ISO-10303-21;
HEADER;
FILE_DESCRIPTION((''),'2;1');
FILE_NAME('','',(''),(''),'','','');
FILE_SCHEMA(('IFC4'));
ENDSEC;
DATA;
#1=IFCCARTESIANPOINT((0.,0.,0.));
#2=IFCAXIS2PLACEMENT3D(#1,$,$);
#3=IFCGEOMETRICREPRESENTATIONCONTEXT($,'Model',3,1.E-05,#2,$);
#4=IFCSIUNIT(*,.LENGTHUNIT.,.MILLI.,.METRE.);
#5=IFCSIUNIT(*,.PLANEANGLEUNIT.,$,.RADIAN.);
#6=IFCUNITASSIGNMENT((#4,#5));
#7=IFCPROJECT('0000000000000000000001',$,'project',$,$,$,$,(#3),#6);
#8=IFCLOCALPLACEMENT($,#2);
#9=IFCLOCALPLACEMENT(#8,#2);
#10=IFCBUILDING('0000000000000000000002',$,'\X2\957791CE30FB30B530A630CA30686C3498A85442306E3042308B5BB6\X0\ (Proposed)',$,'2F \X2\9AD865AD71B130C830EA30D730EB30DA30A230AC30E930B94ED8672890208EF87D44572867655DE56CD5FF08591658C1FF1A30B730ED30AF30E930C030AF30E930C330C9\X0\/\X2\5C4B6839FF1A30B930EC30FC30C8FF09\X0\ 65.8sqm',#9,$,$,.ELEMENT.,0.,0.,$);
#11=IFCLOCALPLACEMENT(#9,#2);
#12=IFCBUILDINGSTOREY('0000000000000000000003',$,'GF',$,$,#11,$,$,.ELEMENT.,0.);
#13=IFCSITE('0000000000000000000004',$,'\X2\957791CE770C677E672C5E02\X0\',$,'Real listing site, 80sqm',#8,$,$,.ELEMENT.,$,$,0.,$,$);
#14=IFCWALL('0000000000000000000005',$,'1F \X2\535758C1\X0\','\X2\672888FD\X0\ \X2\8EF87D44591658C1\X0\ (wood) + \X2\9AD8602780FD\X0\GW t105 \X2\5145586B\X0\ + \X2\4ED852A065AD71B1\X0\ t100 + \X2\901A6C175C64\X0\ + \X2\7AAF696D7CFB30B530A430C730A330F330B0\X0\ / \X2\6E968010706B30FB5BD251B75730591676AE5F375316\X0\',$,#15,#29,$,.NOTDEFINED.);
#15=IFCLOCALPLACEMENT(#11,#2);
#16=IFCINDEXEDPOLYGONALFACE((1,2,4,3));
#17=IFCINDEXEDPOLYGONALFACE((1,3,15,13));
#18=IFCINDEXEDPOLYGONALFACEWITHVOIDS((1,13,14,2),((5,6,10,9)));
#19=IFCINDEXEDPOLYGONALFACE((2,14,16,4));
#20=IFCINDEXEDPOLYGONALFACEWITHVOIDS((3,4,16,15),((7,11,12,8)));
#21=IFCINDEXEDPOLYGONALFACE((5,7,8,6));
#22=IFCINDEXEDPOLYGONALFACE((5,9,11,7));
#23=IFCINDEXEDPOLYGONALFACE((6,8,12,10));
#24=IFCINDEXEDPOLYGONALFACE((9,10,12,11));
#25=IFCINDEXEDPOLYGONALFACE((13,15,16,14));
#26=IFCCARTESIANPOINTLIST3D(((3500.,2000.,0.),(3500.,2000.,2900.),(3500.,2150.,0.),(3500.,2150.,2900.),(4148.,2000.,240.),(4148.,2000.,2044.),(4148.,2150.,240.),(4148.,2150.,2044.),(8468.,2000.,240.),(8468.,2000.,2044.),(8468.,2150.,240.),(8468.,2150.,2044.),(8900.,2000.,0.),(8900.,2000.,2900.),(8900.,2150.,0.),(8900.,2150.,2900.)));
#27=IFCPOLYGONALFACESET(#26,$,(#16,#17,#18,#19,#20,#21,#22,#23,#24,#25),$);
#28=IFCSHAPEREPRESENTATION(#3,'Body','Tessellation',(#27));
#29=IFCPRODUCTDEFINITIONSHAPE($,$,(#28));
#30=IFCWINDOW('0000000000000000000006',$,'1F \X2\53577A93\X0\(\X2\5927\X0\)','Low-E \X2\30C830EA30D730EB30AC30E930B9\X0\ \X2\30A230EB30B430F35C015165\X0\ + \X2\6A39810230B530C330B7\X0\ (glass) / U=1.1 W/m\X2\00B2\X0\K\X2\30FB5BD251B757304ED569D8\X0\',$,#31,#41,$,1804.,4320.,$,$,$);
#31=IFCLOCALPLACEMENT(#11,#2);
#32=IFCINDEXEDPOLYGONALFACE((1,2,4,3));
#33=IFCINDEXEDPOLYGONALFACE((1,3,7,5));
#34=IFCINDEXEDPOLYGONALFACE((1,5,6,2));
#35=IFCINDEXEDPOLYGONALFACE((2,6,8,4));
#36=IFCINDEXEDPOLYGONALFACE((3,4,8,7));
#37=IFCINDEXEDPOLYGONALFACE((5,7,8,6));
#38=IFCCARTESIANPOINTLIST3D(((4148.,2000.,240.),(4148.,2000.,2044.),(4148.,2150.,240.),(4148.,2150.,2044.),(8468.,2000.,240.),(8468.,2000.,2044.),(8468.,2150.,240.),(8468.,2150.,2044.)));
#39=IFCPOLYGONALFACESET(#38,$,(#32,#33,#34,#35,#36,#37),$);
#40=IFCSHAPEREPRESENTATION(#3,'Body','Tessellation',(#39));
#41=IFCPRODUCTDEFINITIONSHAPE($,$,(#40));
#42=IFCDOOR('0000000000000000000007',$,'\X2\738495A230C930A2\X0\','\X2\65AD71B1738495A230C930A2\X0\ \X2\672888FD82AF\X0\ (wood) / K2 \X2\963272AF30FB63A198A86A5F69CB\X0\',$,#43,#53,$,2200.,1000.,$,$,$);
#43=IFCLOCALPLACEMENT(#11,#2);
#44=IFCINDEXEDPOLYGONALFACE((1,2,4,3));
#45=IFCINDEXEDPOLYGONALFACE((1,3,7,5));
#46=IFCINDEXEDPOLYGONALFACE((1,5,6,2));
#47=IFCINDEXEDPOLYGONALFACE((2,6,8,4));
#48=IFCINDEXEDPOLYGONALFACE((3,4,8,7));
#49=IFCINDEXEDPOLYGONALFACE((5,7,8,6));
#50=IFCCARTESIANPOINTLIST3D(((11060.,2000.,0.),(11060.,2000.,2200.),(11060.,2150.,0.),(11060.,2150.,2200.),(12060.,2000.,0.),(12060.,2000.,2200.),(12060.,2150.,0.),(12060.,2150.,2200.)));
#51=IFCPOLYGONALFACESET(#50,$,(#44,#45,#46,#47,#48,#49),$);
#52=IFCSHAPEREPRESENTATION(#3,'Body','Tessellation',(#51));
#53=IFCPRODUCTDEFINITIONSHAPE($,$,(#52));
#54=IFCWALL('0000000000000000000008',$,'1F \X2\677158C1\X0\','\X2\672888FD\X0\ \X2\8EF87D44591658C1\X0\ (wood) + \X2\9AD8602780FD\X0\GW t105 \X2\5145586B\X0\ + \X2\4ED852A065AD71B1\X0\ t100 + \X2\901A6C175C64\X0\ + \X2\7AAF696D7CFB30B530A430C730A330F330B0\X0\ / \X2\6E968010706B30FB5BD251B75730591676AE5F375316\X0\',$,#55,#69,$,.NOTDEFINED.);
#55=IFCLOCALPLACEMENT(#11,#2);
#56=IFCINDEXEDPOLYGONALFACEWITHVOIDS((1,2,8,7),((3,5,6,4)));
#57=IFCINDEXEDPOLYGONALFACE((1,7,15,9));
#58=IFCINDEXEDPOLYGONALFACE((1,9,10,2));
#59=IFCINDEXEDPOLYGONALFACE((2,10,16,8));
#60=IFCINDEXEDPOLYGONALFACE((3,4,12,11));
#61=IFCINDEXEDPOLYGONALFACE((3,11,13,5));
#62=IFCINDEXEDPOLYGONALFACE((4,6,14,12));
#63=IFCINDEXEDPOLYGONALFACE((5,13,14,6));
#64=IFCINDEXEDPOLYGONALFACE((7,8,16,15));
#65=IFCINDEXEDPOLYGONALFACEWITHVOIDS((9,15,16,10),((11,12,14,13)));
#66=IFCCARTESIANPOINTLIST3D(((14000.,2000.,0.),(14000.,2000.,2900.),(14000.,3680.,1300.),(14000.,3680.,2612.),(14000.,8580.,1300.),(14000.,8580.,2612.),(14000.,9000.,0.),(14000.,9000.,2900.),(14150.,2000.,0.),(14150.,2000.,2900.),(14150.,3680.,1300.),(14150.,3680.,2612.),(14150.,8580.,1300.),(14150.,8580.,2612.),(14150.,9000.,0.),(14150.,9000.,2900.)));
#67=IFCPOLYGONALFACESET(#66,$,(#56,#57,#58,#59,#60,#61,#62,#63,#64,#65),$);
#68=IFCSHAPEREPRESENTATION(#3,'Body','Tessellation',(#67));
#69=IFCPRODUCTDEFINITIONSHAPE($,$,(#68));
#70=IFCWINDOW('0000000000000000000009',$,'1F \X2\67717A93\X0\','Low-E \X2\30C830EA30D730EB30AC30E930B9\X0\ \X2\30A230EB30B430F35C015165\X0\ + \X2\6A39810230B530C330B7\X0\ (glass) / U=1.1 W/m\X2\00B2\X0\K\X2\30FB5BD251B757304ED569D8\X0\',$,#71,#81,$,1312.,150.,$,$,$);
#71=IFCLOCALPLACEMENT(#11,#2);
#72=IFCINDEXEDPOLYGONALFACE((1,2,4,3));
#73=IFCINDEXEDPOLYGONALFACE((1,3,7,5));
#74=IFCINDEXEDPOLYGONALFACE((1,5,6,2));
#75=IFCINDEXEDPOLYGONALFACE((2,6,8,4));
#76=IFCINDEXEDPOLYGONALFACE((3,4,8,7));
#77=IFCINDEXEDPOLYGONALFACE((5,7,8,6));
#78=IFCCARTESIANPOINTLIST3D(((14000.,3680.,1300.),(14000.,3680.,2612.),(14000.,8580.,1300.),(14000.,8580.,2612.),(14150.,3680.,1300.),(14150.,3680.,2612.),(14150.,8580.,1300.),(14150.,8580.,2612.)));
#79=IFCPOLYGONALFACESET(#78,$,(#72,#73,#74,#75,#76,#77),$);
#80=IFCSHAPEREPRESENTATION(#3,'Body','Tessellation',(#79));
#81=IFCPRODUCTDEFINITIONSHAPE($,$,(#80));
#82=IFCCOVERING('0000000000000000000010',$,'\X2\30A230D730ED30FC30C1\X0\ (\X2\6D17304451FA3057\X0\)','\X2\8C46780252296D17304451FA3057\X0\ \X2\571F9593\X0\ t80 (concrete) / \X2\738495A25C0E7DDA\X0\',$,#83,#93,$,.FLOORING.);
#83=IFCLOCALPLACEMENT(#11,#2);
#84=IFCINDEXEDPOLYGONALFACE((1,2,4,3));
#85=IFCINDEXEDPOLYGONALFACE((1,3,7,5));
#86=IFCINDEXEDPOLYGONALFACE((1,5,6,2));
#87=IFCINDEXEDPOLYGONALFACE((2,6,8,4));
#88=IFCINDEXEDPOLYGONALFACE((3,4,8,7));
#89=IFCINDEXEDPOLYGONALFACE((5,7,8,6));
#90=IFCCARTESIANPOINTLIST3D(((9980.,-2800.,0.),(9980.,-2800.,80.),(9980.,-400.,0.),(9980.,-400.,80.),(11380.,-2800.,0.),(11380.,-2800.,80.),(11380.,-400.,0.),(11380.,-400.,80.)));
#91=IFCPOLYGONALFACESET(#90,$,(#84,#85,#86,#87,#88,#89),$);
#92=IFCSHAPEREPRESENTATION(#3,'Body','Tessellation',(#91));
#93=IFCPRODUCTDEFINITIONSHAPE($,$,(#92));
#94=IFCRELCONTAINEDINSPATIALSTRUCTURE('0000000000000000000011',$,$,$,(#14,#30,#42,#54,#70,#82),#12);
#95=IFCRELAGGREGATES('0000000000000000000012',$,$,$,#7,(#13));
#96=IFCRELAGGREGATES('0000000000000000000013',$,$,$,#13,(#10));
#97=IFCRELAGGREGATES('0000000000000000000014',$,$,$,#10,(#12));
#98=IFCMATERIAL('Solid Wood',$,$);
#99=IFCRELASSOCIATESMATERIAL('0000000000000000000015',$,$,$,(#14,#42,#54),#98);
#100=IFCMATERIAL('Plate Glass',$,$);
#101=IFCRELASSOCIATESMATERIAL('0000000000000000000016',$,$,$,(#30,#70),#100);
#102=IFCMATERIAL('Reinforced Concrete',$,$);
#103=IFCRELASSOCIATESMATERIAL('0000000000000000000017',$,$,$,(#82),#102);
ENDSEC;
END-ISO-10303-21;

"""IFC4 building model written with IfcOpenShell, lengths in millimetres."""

from ifc_helpers import new_model, si_unit, frame, frame_2d, origin, place, context, project, spatial, rectangle, extrude, material, element, fill, save


model = new_model("IFC4")

# Units and contexts
model_context = context("Model", 3, precision=1e-05, world=origin())
ifc_project = project(units=[si_unit("LENGTHUNIT", "METRE", prefix="MILLI"), si_unit("PLANEANGLEUNIT", "RADIAN")], contexts=[model_context])

# Site, building, storey
site_placement = place(None, origin())
site = spatial("IfcSite", under=ifc_project, at=site_placement, Name="長野県松本市", ObjectType="Real listing site, 80sqm", CompositionType="ELEMENT", RefElevation=0.0)
building_placement = place(site_placement, origin())
building = spatial("IfcBuilding", under=site, at=building_placement, Name="長野・サウナと水風呂のある家 (Proposed)", ObjectType="2F 高断熱トリプルペアガラス付木造軸組在来工法（外壁：シロクラダクラッド/屋根：スレート） 65.8sqm", CompositionType="ELEMENT", ElevationOfRefHeight=0.0, ElevationOfTerrain=0.0)
storey_placement = place(building_placement, origin())
storey = spatial("IfcBuildingStorey", under=building, at=storey_placement, Name="GF", CompositionType="ELEMENT", Elevation=0.0)

# Shared definitions
ifc_material_1 = material(Name="Solid Wood")

# Shared definitions
ifc_material_2 = material(Name="Reinforced Concrete")

# Wall, openings, window, door
wall_1_placement = place(storey_placement, frame((1750.0, 1000.0, 0.0)))
wall_1 = element("IfcWall", 1, at=wall_1_placement, inside=storey, material=ifc_material_1, Name="1F 南壁", Description="木製 軸組外壁 (wood) + 高性能GW t105 充填 + 付加断熱 t100 + 通気層 + 窯業系サイディング / 準耐火・寒冷地外皮強化", PredefinedType="NOTDEFINED", context=model_context, shape_type="SweptSolid", body=[
    extrude(rectangle(XDim=5400.0, YDim=150.0, at=frame_2d((2700.0, 75.0))), frame((1750.0, 1000.0, 0.0)), (0.0, 0.0, 1.0), 2900.0),
])
opening_1_placement = place(storey_placement, frame((2074.0, 1000.0, 120.0)))
opening_1 = element("IfcOpeningElement", 2, at=opening_1_placement, cuts=wall_1, PredefinedType="NOTDEFINED", context=model_context, shape_type="SweptSolid", body=[
    extrude(rectangle(XDim=4320.0, YDim=150.0, at=frame_2d((2160.0, 75.0))), frame((2074.0, 1000.0, 120.0)), (0.0, 0.0, 1.0), 1804.0),
])
opening_2_placement = place(storey_placement, frame((5530.0, 1000.0, 0.0)))
opening_2 = element("IfcOpeningElement", 3, at=opening_2_placement, cuts=wall_1, PredefinedType="NOTDEFINED", context=model_context, shape_type="SweptSolid", body=[
    extrude(rectangle(XDim=1000.0, YDim=150.0, at=frame_2d((500.0, 75.0))), frame((5530.0, 1000.0, 0.0)), (0.0, 0.0, 1.0), 2200.0),
])
ifc_material_3 = material(Name="Plate Glass")
window_1_placement = place(storey_placement, frame((2074.0, 1000.0, 120.0)))
window_1 = element("IfcWindow", 4, at=window_1_placement, inside=storey, material=ifc_material_3, Name="1F 南窓(大)", Description="Low-E トリプルガラス アルゴン封入 + 樹脂サッシ (glass) / U=1.1 W/m²K・寒冷地仕様", OverallHeight=1804.0, OverallWidth=4320.0, context=model_context, shape_type="SweptSolid", body=[
    extrude(rectangle(XDim=4320.0, YDim=150.0, at=frame_2d((2160.0, 75.0))), frame((2074.0, 1000.0, 120.0)), (0.0, 0.0, 1.0), 1804.0),
])
fill(opening_1, window_1)
door_placement = place(storey_placement, frame((5530.0, 1000.0, 0.0)))
door = element("IfcDoor", 5, at=door_placement, inside=storey, material=ifc_material_1, Name="玄関ドア", Description="断熱玄関ドア 木製芯 (wood) / K2 防犯・採風機構", OverallHeight=2200.0, OverallWidth=1000.0, context=model_context, shape_type="SweptSolid", body=[
    extrude(rectangle(XDim=1000.0, YDim=150.0, at=frame_2d((500.0, 75.0))), frame((5530.0, 1000.0, 0.0)), (0.0, 0.0, 1.0), 2200.0),
])
fill(opening_2, door)

# Wall, opening, window
wall_2_placement = place(storey_placement, frame((7000.0, 1000.0, 0.0)))
wall_2 = element("IfcWall", 6, at=wall_2_placement, inside=storey, material=ifc_material_1, Name="1F 東壁", Description="木製 軸組外壁 (wood) + 高性能GW t105 充填 + 付加断熱 t100 + 通気層 + 窯業系サイディング / 準耐火・寒冷地外皮強化", PredefinedType="NOTDEFINED", context=model_context, shape_type="SweptSolid", body=[
    extrude(rectangle(XDim=150.0, YDim=7000.0, at=frame_2d((75.0, 3500.0))), frame((7000.0, 1000.0, 0.0)), (0.0, 0.0, 1.0), 2900.0),
])
opening_3_placement = place(storey_placement, frame((7000.0, 1840.0, 650.0)))
opening_3 = element("IfcOpeningElement", 7, at=opening_3_placement, cuts=wall_2, PredefinedType="NOTDEFINED", context=model_context, shape_type="SweptSolid", body=[
    extrude(rectangle(XDim=150.0, YDim=4900.0, at=frame_2d((75.0, 2450.0))), frame((7000.0, 1840.0, 650.0)), (0.0, 0.0, 1.0), 1312.0),
])
window_2_placement = place(storey_placement, frame((7000.0, 1840.0, 650.0)))
window_2 = element("IfcWindow", 8, at=window_2_placement, inside=storey, material=ifc_material_3, Name="1F 東窓", Description="Low-E トリプルガラス アルゴン封入 + 樹脂サッシ (glass) / U=1.1 W/m²K・寒冷地仕様", OverallHeight=1312.0, OverallWidth=150.0, context=model_context, shape_type="SweptSolid", body=[
    extrude(rectangle(XDim=150.0, YDim=4900.0, at=frame_2d((75.0, 2450.0))), frame((7000.0, 1840.0, 650.0)), (0.0, 0.0, 1.0), 1312.0),
])
fill(opening_3, window_2)

# Covering
covering_1_placement = place(storey_placement, frame((4990.0, -1400.0, 0.0)))
element("IfcCovering", 9, at=covering_1_placement, inside=storey, material=ifc_material_2, Name="アプローチ (洗い出し)", Description="豆砂利洗い出し 土間 t80 (concrete) / 玄関導線", PredefinedType="FLOORING", context=model_context, shape_type="SweptSolid", body=[
    extrude(rectangle(XDim=1400.0, YDim=2400.0, at=frame_2d((700.0, 1200.0))), frame((4990.0, -1400.0, 0.0)), (0.0, 0.0, 1.0), 80.0),
])

save(model, "model.ifc")
